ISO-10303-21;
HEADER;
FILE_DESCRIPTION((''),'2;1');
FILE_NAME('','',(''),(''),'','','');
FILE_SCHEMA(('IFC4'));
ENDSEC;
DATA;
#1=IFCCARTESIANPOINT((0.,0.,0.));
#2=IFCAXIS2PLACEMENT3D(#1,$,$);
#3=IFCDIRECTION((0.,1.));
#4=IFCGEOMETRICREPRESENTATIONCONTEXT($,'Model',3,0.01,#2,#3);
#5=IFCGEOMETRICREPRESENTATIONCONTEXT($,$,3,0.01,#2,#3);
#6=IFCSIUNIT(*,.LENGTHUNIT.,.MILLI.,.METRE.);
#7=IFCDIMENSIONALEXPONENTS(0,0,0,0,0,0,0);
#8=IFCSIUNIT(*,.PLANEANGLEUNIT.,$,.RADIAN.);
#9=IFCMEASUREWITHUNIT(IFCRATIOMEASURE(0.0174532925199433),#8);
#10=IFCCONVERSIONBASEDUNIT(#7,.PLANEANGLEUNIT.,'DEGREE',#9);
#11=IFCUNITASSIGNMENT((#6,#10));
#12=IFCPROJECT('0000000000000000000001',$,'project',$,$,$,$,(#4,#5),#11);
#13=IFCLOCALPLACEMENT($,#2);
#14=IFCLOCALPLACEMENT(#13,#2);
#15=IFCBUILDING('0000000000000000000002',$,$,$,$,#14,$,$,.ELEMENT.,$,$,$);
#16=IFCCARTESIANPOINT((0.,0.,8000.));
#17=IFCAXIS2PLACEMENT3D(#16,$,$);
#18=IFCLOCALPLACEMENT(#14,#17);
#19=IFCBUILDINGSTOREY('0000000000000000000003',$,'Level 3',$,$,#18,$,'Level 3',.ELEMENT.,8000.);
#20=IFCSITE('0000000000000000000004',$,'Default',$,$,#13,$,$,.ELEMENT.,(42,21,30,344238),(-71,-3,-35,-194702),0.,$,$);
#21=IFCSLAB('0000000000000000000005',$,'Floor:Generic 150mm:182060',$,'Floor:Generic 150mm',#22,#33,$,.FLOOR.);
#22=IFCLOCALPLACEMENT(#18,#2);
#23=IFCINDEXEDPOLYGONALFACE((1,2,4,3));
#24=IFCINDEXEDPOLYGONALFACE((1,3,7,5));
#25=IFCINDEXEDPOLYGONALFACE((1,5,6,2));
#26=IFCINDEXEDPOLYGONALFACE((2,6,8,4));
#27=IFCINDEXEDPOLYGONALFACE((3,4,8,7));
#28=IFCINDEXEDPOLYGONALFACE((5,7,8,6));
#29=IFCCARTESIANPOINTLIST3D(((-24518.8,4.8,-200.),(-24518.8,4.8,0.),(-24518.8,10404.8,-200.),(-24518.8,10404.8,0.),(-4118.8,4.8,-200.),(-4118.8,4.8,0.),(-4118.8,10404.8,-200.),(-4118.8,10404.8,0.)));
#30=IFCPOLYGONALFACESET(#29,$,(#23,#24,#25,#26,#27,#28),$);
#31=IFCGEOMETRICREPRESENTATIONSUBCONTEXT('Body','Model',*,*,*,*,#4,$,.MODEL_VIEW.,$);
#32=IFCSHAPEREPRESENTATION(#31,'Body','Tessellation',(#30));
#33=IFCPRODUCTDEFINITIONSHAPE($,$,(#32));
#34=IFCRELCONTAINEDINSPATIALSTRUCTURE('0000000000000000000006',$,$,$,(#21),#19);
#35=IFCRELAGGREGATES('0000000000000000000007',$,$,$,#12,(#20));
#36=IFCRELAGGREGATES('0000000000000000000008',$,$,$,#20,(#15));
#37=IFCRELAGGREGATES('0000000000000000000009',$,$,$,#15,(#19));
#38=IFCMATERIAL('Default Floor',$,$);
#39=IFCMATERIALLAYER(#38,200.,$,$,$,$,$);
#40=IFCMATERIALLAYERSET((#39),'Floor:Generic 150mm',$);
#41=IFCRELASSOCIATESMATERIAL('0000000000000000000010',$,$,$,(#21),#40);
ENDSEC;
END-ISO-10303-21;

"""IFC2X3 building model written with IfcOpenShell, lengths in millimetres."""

from ifc_helpers import new_model, entity, si_unit, converted_unit, direction, frame, origin, origin_2d_with_axis, place, context, subcontext, project, spatial, rectangle, extrude, material, layer, layer_set, layer_usage, element, save


model = new_model("IFC2X3")

# Units and contexts
model_context = context("Model", 3, precision=0.01, world=origin(), true_north=direction((0.0, 1.0)))
context_of_model = context(None, 3, precision=0.01, world=origin(), true_north=direction((0.0, 1.0)))
body_context = subcontext(model_context, "Body", "Model", "MODEL_VIEW")
ifc_project = project(units=[si_unit("LENGTHUNIT", "METRE", prefix="MILLI"), converted_unit("PLANEANGLEUNIT", "DEGREE", entity("IfcRatioMeasure", 0.0174532925199433), si_unit("PLANEANGLEUNIT", "RADIAN"), dimensions=[0, 0, 0, 0, 0, 0, 0])], contexts=[model_context, context_of_model])

# Site, building, storey
site_placement = place(None, origin())
site = spatial("IfcSite", under=ifc_project, at=site_placement, Name="Default", CompositionType="ELEMENT", RefLatitude=(42, 21, 30, 344238), RefLongitude=(-71, -3, -35, -194702), RefElevation=0.0)
building_placement = place(site_placement, origin())
building = spatial("IfcBuilding", under=site, at=building_placement, CompositionType="ELEMENT")
storey_placement = place(building_placement, frame((0.0, 0.0, 8000.0)))
storey = spatial("IfcBuildingStorey", under=building, at=storey_placement, Name="Level 3", LongName="Level 3", CompositionType="ELEMENT", Elevation=8000.0)

# Slab
ifc_material = material(Name="Default Floor")
ifc_layer = layer(ifc_material, 200.0)
ifc_layer_set = layer_set([ifc_layer], Name="Floor:Generic 150mm")
ifc_layer_usage = layer_usage(ifc_layer_set, "AXIS3", "POSITIVE", 0.0)
slab_placement = place(storey_placement, origin())
element("IfcSlab", 1, at=slab_placement, inside=storey, material=ifc_layer_usage, Name="Floor:Generic 150mm:182060", ObjectType="Floor:Generic 150mm", PredefinedType="FLOOR", context=body_context, shape_type="SweptSolid", body=[
    extrude(rectangle(XDim=10400.0, YDim=20400.0, at=origin_2d_with_axis()), frame((-14318.8, 5204.8, 0.0), z_axis=(0.0, 0.0, -1.0), x_axis=(0.0, 1.0, 0.0)), (0.0, 0.0, 1.0), 200.0),
])

save(model, "model.ifc")
